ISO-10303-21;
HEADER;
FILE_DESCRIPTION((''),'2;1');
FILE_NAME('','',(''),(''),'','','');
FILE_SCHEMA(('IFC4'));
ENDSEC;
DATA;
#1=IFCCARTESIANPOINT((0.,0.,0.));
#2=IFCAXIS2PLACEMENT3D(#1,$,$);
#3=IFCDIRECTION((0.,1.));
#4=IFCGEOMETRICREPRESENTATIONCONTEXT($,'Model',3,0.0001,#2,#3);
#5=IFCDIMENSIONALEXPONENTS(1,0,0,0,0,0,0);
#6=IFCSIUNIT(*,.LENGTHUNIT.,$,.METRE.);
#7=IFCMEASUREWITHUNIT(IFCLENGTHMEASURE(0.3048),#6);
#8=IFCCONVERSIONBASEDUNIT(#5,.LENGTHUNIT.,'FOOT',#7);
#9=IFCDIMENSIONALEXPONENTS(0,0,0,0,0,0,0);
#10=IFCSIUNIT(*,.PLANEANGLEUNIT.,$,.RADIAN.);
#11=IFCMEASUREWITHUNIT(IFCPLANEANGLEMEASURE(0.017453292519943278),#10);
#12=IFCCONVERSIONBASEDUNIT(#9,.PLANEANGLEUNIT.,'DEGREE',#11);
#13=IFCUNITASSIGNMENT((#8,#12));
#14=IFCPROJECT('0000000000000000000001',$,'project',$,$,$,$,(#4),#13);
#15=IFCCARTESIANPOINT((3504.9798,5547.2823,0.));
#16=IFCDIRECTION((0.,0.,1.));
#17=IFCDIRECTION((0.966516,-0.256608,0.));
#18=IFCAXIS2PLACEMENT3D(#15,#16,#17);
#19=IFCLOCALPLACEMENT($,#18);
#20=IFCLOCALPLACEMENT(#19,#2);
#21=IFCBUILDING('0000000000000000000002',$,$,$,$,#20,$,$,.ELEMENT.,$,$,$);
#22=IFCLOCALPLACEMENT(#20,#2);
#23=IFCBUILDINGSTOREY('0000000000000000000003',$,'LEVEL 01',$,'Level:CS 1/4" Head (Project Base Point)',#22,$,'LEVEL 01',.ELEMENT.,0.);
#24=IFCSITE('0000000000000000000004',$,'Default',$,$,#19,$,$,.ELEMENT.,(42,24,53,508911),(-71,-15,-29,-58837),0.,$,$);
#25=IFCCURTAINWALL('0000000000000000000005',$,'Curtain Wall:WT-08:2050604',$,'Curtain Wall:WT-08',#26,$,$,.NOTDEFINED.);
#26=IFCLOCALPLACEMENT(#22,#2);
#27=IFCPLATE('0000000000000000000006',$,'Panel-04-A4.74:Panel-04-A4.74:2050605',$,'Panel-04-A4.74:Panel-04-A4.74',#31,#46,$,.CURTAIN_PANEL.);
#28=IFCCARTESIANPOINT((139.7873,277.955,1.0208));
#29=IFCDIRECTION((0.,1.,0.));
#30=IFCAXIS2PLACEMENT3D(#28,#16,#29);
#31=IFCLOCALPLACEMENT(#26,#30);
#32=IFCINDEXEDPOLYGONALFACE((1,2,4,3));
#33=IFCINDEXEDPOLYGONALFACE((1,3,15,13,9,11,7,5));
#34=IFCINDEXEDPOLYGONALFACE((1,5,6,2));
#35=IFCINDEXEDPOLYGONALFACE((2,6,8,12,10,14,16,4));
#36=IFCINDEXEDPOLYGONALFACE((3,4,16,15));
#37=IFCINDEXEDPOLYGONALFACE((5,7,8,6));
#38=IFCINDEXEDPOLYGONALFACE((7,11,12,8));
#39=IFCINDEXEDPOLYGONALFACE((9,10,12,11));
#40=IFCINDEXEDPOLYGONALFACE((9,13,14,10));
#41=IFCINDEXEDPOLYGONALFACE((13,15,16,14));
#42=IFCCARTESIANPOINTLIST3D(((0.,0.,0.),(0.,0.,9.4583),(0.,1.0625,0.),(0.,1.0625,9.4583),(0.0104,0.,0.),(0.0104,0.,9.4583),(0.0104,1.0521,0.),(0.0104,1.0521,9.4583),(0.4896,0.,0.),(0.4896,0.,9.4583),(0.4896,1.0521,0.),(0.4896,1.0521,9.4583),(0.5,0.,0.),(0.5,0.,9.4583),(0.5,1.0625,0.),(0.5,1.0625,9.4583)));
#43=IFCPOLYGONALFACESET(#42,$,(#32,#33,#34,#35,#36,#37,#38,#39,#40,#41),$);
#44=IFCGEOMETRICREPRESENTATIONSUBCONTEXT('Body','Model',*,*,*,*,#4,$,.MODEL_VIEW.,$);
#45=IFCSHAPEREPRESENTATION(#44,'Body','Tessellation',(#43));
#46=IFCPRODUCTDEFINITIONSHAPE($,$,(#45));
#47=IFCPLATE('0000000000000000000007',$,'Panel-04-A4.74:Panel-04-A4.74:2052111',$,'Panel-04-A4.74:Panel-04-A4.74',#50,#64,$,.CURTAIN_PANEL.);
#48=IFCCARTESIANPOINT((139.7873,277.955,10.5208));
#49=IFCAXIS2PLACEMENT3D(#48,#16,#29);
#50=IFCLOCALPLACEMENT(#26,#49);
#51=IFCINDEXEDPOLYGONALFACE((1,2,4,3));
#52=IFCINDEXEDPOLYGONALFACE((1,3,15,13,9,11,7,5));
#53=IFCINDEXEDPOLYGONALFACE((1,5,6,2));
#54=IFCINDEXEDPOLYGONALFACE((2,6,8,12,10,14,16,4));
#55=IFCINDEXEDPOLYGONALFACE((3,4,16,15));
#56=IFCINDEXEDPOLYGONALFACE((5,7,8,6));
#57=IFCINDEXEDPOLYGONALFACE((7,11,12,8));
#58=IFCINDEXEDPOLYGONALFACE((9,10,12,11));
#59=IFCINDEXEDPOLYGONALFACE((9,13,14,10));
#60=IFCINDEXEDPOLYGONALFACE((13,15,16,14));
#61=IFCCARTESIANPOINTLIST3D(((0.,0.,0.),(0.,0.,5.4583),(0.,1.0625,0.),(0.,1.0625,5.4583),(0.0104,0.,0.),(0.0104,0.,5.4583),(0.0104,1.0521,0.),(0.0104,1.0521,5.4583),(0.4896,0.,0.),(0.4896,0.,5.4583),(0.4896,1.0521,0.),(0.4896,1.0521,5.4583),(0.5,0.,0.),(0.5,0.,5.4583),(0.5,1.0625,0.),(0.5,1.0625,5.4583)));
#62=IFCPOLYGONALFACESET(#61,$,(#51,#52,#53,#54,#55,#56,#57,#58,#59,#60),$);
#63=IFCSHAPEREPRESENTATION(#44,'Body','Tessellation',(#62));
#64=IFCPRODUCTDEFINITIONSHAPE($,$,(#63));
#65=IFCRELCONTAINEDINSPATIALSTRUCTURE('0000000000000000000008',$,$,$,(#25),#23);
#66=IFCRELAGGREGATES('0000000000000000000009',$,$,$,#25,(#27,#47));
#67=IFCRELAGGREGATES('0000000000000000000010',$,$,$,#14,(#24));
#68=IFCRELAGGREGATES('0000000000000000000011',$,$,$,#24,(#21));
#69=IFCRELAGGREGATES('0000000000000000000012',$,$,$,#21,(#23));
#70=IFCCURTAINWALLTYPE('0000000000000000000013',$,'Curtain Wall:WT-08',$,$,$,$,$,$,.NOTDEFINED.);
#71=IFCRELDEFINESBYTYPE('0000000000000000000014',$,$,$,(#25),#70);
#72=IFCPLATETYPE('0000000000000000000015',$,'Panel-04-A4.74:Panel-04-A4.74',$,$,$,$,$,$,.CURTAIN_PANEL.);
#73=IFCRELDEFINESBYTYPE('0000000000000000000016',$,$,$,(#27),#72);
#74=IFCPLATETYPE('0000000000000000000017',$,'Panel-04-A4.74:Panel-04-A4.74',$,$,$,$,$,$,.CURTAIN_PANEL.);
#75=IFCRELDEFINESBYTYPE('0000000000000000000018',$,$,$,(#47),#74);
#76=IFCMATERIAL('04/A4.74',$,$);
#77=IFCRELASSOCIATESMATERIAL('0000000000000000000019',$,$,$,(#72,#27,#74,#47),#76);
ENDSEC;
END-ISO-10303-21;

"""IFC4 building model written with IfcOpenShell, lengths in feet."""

from ifc_helpers import new_model, entity, si_unit, converted_unit, direction, frame, origin, place, context, subcontext, project, spatial, indexed_curve, outline, extrude, source, transform, mapped, material, type_object, type_shapes, element, aggregate, save


model = new_model("IFC4")

# Units and contexts
model_context = context("Model", 3, precision=0.0001, world=origin(), true_north=direction((0.0, 1.0)))
body_context = subcontext(model_context, "Body", "Model", "MODEL_VIEW")
ifc_project = project(units=[converted_unit("LENGTHUNIT", "FOOT", entity("IfcLengthMeasure", 0.3048), si_unit("LENGTHUNIT", "METRE"), dimensions=[1, 0, 0, 0, 0, 0, 0]), converted_unit("PLANEANGLEUNIT", "DEGREE", entity("IfcPlaneAngleMeasure", 0.017453292519943278), si_unit("PLANEANGLEUNIT", "RADIAN"), dimensions=[0, 0, 0, 0, 0, 0, 0])], contexts=[model_context])

# Site, building, storey
site_placement = place(None, frame((3504.9798, 5547.2823, 0.0), z_axis=(0.0, 0.0, 1.0), x_axis=(0.966516, -0.256608, 0.0)))
site = spatial("IfcSite", under=ifc_project, at=site_placement, Name="Default", CompositionType="ELEMENT", RefLatitude=(42, 24, 53, 508911), RefLongitude=(-71, -15, -29, -58837), RefElevation=0.0)
building_placement = place(site_placement, origin())
building = spatial("IfcBuilding", under=site, at=building_placement, CompositionType="ELEMENT")
storey_placement = place(building_placement, origin())
storey = spatial("IfcBuildingStorey", under=building, at=storey_placement, Name="LEVEL 01", ObjectType="Level:CS 1/4\" Head (Project Base Point)", LongName="LEVEL 01", CompositionType="ELEMENT", Elevation=0.0)

# Shared definitions
curtain_wall_type_1 = type_object("IfcCurtainWallType", Name="Curtain Wall:WT-08", PredefinedType="NOTDEFINED")

# Curtain wall, plates
curtain_wall_1_placement = place(storey_placement, origin())
curtain_wall_1 = element("IfcCurtainWall", 1, at=curtain_wall_1_placement, inside=storey, type_object=curtain_wall_type_1, Name="Curtain Wall:WT-08:2050604", ObjectType="Curtain Wall:WT-08", PredefinedType="NOTDEFINED")
ifc_material_1 = material(Name="04/A4.74")
plate_type_1 = type_object("IfcPlateType", Name="Panel-04-A4.74:Panel-04-A4.74", PredefinedType="CURTAIN_PANEL", material=ifc_material_1)
shared_shape_1 = source(origin(), body_context, "Body", "SweptSolid", [
    extrude(outline(indexed_curve([(-0.25, -0.5339), (0.25, -0.5339), (0.25, 0.5286), (0.2396, 0.5286), (0.2396, -0.5234), (-0.2396, -0.5234), (-0.2396, 0.5286), (-0.25, 0.5286), (-0.25, -0.5339)], self_intersect=False)), frame((0.25, 0.5286, 0.0), z_axis=(0.0, 0.0, 1.0), x_axis=(-1.0, 0.0, 0.0)), (0.0, 0.0, 1.0), 9.4583),
])
type_shapes(plate_type_1, [shared_shape_1])
plate_1_placement = place(curtain_wall_1_placement, frame((139.7873, 277.955, 1.0208), z_axis=(0.0, 0.0, 1.0), x_axis=(0.0, 1.0, 0.0)))
plate_1 = element("IfcPlate", 2, at=plate_1_placement, type_object=plate_type_1, material=ifc_material_1, Name="Panel-04-A4.74:Panel-04-A4.74:2050605", ObjectType="Panel-04-A4.74:Panel-04-A4.74", PredefinedType="CURTAIN_PANEL", context=body_context, shape_type="MappedRepresentation", body=[
    mapped(shared_shape_1, transform((0.0, 0.0, 0.0), scale=1.0)),
])
plate_type_2 = type_object("IfcPlateType", Name="Panel-04-A4.74:Panel-04-A4.74", PredefinedType="CURTAIN_PANEL", material=ifc_material_1)
shared_shape_2 = source(origin(), body_context, "Body", "SweptSolid", [
    extrude(outline(indexed_curve([(-0.25, -0.5339), (0.25, -0.5339), (0.25, 0.5286), (0.2396, 0.5286), (0.2396, -0.5234), (-0.2396, -0.5234), (-0.2396, 0.5286), (-0.25, 0.5286), (-0.25, -0.5339)], self_intersect=False)), frame((0.25, 0.5286, 0.0), z_axis=(0.0, 0.0, 1.0), x_axis=(-1.0, 0.0, 0.0)), (0.0, 0.0, 1.0), 5.4583),
])
type_shapes(plate_type_2, [shared_shape_2])
plate_2_placement = place(curtain_wall_1_placement, frame((139.7873, 277.955, 10.5208), z_axis=(0.0, 0.0, 1.0), x_axis=(0.0, 1.0, 0.0)))
plate_2 = element("IfcPlate", 3, at=plate_2_placement, type_object=plate_type_2, material=ifc_material_1, Name="Panel-04-A4.74:Panel-04-A4.74:2052111", ObjectType="Panel-04-A4.74:Panel-04-A4.74", PredefinedType="CURTAIN_PANEL", context=body_context, shape_type="MappedRepresentation", body=[
    mapped(shared_shape_2, transform((0.0, 0.0, 0.0), scale=1.0)),
])
aggregate(curtain_wall_1, [plate_1, plate_2])

save(model, "model.ifc")
